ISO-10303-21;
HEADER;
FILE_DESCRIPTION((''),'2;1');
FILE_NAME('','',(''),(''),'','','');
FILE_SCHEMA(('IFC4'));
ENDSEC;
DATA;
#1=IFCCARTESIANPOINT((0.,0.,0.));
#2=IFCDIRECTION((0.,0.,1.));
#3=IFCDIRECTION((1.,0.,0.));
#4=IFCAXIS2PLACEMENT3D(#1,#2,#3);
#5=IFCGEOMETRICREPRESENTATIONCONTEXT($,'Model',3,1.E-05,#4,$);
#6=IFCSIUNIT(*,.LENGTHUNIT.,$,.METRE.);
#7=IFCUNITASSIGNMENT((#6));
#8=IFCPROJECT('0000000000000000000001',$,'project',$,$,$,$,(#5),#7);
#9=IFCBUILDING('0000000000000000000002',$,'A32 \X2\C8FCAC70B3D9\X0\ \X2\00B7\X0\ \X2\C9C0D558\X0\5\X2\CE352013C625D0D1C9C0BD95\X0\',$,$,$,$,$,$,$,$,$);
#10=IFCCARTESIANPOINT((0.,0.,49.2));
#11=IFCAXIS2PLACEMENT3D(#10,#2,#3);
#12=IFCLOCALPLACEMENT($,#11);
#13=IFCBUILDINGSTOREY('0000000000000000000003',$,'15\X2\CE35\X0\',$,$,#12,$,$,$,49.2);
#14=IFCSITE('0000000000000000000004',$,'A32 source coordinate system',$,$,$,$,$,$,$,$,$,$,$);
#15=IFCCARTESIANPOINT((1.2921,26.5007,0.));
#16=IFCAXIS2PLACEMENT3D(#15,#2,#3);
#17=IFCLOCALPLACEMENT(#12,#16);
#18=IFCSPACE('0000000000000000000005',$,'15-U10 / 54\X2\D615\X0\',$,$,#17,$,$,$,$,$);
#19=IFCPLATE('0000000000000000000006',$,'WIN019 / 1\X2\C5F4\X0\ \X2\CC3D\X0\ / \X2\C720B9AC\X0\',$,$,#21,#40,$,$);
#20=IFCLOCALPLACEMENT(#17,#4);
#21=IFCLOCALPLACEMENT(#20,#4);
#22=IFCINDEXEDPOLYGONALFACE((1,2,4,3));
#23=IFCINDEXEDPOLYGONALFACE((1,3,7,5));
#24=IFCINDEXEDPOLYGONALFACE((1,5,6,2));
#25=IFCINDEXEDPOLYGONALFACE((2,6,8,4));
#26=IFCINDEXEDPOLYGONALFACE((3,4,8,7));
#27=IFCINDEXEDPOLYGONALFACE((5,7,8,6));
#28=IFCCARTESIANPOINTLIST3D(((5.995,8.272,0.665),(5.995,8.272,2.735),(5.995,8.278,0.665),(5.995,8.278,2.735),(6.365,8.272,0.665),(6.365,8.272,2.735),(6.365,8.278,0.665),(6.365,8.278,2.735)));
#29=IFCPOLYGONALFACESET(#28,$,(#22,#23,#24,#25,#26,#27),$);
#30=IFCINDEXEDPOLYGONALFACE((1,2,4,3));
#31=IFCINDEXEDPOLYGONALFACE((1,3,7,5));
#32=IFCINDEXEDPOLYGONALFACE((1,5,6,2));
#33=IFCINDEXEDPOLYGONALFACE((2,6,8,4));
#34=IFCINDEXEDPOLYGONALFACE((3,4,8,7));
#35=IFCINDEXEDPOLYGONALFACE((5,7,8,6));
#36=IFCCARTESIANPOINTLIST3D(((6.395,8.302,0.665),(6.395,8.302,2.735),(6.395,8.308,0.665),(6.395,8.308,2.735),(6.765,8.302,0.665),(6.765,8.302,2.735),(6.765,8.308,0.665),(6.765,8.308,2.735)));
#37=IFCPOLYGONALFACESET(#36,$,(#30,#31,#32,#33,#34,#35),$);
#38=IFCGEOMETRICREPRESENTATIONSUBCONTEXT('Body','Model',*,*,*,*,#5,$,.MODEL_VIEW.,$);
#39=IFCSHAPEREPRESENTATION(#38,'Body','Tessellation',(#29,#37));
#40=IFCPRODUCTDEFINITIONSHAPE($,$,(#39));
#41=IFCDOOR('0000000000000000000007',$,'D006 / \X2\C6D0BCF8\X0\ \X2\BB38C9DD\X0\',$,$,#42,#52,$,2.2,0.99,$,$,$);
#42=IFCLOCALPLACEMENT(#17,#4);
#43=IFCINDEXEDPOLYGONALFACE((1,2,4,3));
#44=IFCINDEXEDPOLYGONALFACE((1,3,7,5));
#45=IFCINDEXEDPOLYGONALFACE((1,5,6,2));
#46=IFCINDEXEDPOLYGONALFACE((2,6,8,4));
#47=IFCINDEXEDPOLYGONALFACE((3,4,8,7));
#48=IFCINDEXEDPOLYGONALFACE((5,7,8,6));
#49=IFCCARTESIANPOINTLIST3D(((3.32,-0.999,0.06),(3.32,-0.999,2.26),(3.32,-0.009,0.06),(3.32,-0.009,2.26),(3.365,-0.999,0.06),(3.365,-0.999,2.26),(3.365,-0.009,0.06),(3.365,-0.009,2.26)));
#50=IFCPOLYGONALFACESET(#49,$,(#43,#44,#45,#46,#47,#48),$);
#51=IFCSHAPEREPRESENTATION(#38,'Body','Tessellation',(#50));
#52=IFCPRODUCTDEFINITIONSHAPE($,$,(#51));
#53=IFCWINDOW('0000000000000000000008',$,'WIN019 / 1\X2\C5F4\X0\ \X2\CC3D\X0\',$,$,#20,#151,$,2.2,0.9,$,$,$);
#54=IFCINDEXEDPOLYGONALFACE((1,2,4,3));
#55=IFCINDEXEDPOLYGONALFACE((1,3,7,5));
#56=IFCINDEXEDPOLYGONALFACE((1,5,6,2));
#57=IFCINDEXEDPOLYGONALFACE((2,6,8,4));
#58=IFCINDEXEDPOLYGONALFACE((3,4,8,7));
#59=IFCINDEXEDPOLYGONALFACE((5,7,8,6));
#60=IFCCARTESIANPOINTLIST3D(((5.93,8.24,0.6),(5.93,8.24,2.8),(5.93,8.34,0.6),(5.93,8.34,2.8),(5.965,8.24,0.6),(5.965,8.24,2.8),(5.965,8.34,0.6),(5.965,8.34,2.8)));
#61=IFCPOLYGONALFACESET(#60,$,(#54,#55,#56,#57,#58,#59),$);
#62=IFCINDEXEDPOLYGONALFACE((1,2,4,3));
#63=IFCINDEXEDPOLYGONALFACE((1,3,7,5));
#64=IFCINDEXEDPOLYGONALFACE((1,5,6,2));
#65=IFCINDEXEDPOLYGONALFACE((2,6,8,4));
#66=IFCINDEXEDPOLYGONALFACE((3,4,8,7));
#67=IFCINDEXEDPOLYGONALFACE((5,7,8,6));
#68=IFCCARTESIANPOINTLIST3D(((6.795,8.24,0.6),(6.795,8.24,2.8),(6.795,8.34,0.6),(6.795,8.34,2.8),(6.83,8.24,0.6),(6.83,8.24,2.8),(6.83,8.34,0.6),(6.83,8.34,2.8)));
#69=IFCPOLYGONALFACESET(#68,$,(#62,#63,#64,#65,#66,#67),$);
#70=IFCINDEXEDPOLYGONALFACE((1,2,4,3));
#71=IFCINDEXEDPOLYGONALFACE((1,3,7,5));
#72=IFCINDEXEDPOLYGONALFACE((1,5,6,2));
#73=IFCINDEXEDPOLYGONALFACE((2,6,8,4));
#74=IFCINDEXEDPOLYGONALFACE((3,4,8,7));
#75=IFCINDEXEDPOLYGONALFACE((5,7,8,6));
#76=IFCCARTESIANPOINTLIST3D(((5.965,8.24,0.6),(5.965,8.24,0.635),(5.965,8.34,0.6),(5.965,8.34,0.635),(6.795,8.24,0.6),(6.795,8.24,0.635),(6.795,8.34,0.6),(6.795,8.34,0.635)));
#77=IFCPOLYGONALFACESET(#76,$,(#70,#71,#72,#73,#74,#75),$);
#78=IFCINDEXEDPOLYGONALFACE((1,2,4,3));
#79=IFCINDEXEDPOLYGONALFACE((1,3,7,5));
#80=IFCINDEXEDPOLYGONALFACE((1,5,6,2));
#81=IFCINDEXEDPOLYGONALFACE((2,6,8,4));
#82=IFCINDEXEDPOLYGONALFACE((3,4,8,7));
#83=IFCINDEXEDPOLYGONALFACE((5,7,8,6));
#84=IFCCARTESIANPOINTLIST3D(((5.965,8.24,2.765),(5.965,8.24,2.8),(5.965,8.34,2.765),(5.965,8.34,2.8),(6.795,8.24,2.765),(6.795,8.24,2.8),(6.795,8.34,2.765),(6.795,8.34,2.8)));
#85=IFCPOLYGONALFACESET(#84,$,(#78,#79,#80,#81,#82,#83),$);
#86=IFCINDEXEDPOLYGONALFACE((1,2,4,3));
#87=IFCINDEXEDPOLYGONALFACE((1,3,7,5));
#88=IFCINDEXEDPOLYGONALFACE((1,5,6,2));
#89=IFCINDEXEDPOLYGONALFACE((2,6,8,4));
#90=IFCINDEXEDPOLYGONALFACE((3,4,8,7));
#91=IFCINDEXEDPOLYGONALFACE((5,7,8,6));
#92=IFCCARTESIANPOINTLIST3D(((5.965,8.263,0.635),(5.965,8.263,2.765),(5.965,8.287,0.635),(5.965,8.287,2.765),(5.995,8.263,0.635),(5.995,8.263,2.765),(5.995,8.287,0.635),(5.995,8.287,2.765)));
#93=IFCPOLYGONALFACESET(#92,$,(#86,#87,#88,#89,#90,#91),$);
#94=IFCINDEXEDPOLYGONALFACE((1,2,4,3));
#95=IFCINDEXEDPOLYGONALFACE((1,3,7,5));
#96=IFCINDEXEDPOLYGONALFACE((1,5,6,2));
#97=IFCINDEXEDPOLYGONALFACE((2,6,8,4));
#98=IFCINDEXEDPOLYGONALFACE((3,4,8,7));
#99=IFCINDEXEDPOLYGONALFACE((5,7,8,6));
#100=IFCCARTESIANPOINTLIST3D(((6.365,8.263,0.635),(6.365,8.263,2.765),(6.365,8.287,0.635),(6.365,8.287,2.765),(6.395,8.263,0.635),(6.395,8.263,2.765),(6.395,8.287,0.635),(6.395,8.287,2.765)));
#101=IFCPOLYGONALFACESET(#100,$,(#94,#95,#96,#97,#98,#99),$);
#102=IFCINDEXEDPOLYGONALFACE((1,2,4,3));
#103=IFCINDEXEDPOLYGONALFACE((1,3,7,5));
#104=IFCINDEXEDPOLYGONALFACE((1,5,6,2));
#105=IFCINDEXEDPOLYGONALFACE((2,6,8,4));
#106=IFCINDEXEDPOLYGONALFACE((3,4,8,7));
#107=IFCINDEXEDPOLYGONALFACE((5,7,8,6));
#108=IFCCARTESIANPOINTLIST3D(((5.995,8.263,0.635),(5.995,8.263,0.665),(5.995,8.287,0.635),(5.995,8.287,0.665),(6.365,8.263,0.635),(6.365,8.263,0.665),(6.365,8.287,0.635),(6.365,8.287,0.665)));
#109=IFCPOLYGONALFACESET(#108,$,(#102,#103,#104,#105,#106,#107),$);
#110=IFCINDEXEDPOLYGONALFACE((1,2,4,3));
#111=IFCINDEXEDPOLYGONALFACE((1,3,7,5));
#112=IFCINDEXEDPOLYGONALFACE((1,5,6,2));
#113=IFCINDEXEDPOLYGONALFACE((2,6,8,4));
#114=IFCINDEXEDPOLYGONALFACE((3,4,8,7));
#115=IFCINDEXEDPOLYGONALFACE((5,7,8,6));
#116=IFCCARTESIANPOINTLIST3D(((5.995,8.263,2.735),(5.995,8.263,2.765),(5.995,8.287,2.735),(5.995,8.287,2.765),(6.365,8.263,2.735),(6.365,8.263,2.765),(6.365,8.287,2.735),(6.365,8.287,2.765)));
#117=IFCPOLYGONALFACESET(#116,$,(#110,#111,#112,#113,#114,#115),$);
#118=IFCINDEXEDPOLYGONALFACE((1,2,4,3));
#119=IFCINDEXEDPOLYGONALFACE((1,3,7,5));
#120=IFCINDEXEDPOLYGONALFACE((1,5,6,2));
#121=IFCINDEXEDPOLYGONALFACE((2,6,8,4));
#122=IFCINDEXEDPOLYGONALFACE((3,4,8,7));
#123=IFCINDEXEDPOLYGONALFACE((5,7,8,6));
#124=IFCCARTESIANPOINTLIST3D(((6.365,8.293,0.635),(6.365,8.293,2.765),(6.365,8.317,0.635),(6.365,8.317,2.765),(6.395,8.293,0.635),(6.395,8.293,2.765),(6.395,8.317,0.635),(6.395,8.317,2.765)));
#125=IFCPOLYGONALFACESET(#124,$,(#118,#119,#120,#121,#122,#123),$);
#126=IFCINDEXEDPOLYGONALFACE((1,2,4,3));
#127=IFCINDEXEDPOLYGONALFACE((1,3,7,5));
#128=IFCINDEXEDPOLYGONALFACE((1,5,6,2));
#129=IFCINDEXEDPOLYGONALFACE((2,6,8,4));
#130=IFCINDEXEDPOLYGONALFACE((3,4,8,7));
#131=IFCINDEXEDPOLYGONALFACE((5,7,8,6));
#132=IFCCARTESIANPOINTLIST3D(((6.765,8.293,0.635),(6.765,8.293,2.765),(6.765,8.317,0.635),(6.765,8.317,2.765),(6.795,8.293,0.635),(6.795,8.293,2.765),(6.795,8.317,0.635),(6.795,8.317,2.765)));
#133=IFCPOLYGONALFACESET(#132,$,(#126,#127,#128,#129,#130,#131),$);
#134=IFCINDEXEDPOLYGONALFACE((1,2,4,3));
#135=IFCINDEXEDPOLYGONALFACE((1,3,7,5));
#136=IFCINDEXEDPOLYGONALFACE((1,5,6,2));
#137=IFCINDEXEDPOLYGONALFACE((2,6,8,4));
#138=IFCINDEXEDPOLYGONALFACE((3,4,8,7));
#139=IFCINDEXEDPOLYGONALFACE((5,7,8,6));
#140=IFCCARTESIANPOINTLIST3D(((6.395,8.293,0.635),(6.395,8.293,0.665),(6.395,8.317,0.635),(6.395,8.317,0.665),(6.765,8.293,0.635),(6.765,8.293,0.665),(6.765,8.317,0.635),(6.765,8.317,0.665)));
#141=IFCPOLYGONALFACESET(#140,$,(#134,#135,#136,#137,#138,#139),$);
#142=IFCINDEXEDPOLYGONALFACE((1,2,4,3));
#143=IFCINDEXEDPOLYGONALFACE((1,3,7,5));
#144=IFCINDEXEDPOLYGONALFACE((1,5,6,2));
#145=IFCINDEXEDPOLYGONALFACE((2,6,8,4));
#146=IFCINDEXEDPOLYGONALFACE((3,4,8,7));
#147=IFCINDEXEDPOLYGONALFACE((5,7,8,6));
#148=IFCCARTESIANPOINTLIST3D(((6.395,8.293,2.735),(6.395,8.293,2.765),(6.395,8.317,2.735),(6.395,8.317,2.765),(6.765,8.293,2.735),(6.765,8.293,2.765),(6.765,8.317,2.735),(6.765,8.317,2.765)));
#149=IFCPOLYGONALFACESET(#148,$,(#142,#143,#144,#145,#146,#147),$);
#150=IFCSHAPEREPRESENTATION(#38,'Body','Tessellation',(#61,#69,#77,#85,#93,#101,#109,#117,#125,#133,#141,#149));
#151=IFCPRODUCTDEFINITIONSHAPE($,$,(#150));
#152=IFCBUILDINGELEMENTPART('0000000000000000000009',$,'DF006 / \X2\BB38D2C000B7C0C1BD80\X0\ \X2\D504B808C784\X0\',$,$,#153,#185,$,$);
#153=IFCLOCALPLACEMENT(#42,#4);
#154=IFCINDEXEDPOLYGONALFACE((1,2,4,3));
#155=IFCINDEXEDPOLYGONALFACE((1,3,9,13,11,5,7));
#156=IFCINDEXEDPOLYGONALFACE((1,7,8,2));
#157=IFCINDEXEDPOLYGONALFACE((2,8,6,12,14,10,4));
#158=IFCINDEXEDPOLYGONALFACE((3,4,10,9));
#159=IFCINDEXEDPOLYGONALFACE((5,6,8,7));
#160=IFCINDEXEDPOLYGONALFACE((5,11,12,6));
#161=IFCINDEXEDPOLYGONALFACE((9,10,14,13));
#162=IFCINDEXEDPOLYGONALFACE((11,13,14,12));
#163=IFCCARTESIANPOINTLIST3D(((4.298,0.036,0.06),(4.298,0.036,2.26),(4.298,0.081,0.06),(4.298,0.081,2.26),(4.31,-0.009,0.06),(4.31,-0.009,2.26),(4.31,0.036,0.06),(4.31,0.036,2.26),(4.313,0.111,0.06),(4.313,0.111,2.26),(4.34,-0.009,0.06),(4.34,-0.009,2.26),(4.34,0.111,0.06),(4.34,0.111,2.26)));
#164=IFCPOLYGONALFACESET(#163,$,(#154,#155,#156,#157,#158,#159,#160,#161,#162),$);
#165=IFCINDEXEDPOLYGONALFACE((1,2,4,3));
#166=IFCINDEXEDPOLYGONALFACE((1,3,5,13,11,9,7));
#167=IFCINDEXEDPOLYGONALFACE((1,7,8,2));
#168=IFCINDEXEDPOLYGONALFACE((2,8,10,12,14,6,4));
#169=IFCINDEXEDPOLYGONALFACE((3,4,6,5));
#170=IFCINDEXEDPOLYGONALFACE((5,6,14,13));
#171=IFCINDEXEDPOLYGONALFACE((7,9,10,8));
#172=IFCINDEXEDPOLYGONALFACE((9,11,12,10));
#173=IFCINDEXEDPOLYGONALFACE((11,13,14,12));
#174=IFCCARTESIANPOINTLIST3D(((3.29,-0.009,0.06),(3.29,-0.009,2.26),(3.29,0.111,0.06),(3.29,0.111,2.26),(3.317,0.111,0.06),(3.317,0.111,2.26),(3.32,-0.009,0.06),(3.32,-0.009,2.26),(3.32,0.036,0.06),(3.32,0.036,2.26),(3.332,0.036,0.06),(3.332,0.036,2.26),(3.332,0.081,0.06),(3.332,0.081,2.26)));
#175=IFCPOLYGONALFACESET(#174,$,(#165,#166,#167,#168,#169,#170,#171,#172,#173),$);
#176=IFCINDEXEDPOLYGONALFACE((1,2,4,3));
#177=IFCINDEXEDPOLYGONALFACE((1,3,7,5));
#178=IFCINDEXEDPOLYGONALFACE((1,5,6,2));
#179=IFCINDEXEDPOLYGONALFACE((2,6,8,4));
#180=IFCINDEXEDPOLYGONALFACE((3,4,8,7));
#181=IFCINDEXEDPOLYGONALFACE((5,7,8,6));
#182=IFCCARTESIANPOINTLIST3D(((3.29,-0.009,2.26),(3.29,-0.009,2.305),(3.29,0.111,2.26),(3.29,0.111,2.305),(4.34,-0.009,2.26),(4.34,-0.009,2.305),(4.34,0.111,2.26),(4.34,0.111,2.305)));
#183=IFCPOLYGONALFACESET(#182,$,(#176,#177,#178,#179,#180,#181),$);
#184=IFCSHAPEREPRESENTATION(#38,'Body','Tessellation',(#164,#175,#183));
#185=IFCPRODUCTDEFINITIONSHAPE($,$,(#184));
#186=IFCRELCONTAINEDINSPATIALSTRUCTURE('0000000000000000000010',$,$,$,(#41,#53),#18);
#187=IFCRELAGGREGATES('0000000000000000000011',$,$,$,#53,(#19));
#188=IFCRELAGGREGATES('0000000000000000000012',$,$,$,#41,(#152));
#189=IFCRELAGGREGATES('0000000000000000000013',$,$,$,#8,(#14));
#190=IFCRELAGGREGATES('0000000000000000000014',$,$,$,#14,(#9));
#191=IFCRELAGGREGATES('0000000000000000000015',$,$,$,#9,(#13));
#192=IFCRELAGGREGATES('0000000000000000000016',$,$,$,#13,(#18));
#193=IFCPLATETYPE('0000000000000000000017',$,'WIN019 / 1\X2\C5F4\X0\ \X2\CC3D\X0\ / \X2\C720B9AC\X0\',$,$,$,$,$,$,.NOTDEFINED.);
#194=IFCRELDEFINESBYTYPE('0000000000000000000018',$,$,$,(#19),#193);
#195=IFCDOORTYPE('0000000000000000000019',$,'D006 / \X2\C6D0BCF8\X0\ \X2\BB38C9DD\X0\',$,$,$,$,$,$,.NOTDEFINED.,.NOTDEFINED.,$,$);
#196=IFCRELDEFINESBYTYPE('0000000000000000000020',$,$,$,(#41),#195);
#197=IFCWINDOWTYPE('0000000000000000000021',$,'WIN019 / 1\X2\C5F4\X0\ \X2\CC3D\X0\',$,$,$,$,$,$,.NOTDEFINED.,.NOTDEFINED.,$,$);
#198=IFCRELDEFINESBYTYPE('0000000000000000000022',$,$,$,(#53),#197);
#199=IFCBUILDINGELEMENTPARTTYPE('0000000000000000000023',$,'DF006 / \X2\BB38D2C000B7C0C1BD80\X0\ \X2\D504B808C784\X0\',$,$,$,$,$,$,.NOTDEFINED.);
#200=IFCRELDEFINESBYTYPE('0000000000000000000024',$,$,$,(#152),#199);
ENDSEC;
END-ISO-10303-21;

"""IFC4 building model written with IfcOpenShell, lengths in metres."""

from ifc_helpers import new_model, si_unit, frame, origin, origin_with_axes, place, context, subcontext, project, spatial, polyline, outline, extrude, source, transform, mapped, type_object, type_shapes, element, aggregate, save


model = new_model("IFC4")

# Units and contexts
model_context = context("Model", 3, precision=1e-05, world=origin_with_axes())
body_context = subcontext(model_context, "Body", "Model", "MODEL_VIEW")
ifc_project = project(units=[si_unit("LENGTHUNIT", "METRE")], contexts=[model_context])

# Plate
storey_placement = place(None, frame((0.0, 0.0, 49.2), z_axis=(0.0, 0.0, 1.0), x_axis=(1.0, 0.0, 0.0)))
space_placement = place(storey_placement, frame((1.2921, 26.5007, 0.0), z_axis=(0.0, 0.0, 1.0), x_axis=(1.0, 0.0, 0.0)))
plate_type_1 = type_object("IfcPlateType", Name="WIN019 / 1열 창 / 유리", PredefinedType="NOTDEFINED")
shared_shape_1 = source(origin(), body_context, "Body", "SweptSolid", [
    extrude(outline(polyline([(5.995, 8.272), (5.995, 8.278), (6.365, 8.278), (6.365, 8.272), (5.995, 8.272)])), frame((0.0, 0.0, 0.665)), (0.0, 0.0, 1.0), 2.07),
    extrude(outline(polyline([(6.395, 8.302), (6.395, 8.308), (6.765, 8.308), (6.765, 8.302), (6.395, 8.302)])), frame((0.0, 0.0, 0.665)), (0.0, 0.0, 1.0), 2.07),
])
type_shapes(plate_type_1, [shared_shape_1])
window_1_placement = place(space_placement, origin_with_axes())
plate_1_placement = place(window_1_placement, origin_with_axes())
plate_1 = element("IfcPlate", 1, at=plate_1_placement, type_object=plate_type_1, Name="WIN019 / 1열 창 / 유리", context=body_context, shape_type="MappedRepresentation", body=[
    mapped(shared_shape_1, transform((0.0, 0.0, 0.0), scale=1.0)),
])

# Site, building, storey, space
site = spatial("IfcSite", under=ifc_project, Name="A32 source coordinate system")
building = spatial("IfcBuilding", under=site, Name="A32 주거동 · 지하5층–옥탑지붕")
storey = spatial("IfcBuildingStorey", under=building, at=storey_placement, Name="15층", Elevation=49.2)
space = spatial("IfcSpace", under=storey, at=space_placement, Name="15-U10 / 54형")

# Door
door_type_1 = type_object("IfcDoorType", Name="D006 / 원본 문짝", OperationType="NOTDEFINED", PredefinedType="NOTDEFINED")
shared_shape_2 = source(origin(), body_context, "Body", "SweptSolid", [
    extrude(outline(polyline([(3.365, -0.999), (3.32, -0.999), (3.32, -0.009), (3.365, -0.009), (3.365, -0.999)])), frame((0.0, 0.0, 0.06)), (0.0, 0.0, 1.0), 2.2),
])
type_shapes(door_type_1, [shared_shape_2])
door_1_placement = place(space_placement, origin_with_axes())
door_1 = element("IfcDoor", 2, at=door_1_placement, inside=space, type_object=door_type_1, Name="D006 / 원본 문짝", OverallHeight=2.2, OverallWidth=0.99, context=body_context, shape_type="MappedRepresentation", body=[
    mapped(shared_shape_2, transform((0.0, 0.0, 0.0), scale=1.0)),
])

# Window
window_type_1 = type_object("IfcWindowType", Name="WIN019 / 1열 창", PartitioningType="NOTDEFINED", PredefinedType="NOTDEFINED")
shared_shape_3 = source(origin(), body_context, "Body", "SweptSolid", [
    extrude(outline(polyline([(5.93, 8.24), (5.93, 8.34), (5.965, 8.34), (5.965, 8.24), (5.93, 8.24)])), frame((0.0, 0.0, 0.6)), (0.0, 0.0, 1.0), 2.2),
    extrude(outline(polyline([(6.795, 8.24), (6.795, 8.34), (6.83, 8.34), (6.83, 8.24), (6.795, 8.24)])), frame((0.0, 0.0, 0.6)), (0.0, 0.0, 1.0), 2.2),
    extrude(outline(polyline([(5.965, 8.24), (5.965, 8.34), (6.795, 8.34), (6.795, 8.24), (5.965, 8.24)])), frame((0.0, 0.0, 0.6)), (0.0, 0.0, 1.0), 0.035),
    extrude(outline(polyline([(5.965, 8.24), (5.965, 8.34), (6.795, 8.34), (6.795, 8.24), (5.965, 8.24)])), frame((0.0, 0.0, 2.765)), (0.0, 0.0, 1.0), 0.035),
    extrude(outline(polyline([(5.965, 8.263), (5.965, 8.287), (5.995, 8.287), (5.995, 8.263), (5.965, 8.263)])), frame((0.0, 0.0, 0.635)), (0.0, 0.0, 1.0), 2.13),
    extrude(outline(polyline([(6.365, 8.263), (6.365, 8.287), (6.395, 8.287), (6.395, 8.263), (6.365, 8.263)])), frame((0.0, 0.0, 0.635)), (0.0, 0.0, 1.0), 2.13),
    extrude(outline(polyline([(5.995, 8.263), (5.995, 8.287), (6.365, 8.287), (6.365, 8.263), (5.995, 8.263)])), frame((0.0, 0.0, 0.635)), (0.0, 0.0, 1.0), 0.03),
    extrude(outline(polyline([(5.995, 8.263), (5.995, 8.287), (6.365, 8.287), (6.365, 8.263), (5.995, 8.263)])), frame((0.0, 0.0, 2.735)), (0.0, 0.0, 1.0), 0.03),
    extrude(outline(polyline([(6.365, 8.293), (6.365, 8.317), (6.395, 8.317), (6.395, 8.293), (6.365, 8.293)])), frame((0.0, 0.0, 0.635)), (0.0, 0.0, 1.0), 2.13),
    extrude(outline(polyline([(6.765, 8.293), (6.765, 8.317), (6.795, 8.317), (6.795, 8.293), (6.765, 8.293)])), frame((0.0, 0.0, 0.635)), (0.0, 0.0, 1.0), 2.13),
    extrude(outline(polyline([(6.395, 8.293), (6.395, 8.317), (6.765, 8.317), (6.765, 8.293), (6.395, 8.293)])), frame((0.0, 0.0, 0.635)), (0.0, 0.0, 1.0), 0.03),
    extrude(outline(polyline([(6.395, 8.293), (6.395, 8.317), (6.765, 8.317), (6.765, 8.293), (6.395, 8.293)])), frame((0.0, 0.0, 2.735)), (0.0, 0.0, 1.0), 0.03),
])
type_shapes(window_type_1, [shared_shape_3])
window_1 = element("IfcWindow", 3, at=window_1_placement, inside=space, type_object=window_type_1, Name="WIN019 / 1열 창", OverallHeight=2.2, OverallWidth=0.9, context=body_context, shape_type="MappedRepresentation", body=[
    mapped(shared_shape_3, transform((0.0, 0.0, 0.0), scale=1.0)),
])
aggregate(window_1, [plate_1])

# Building element part
building_element_part_type_1 = type_object("IfcBuildingElementPartType", Name="DF006 / 문틀·상부 프레임", PredefinedType="NOTDEFINED")
shared_shape_4 = source(origin(), body_context, "Body", "SweptSolid", [
    extrude(outline(polyline([(4.31, -0.009), (4.31, 0.036), (4.298, 0.036), (4.298, 0.081), (4.313, 0.111), (4.34, 0.111), (4.34, -0.009), (4.31, -0.009)])), frame((0.0, 0.0, 0.06)), (0.0, 0.0, 1.0), 2.2),
    extrude(outline(polyline([(3.29, 0.111), (3.317, 0.111), (3.332, 0.081), (3.332, 0.036), (3.32, 0.036), (3.32, -0.009), (3.29, -0.009), (3.29, 0.111)])), frame((0.0, 0.0, 0.06)), (0.0, 0.0, 1.0), 2.2),
    extrude(outline(polyline([(3.29, -0.009), (3.29, 0.111), (4.34, 0.111), (4.34, -0.009), (3.29, -0.009)])), frame((0.0, 0.0, 2.26)), (0.0, 0.0, 1.0), 0.045),
])
type_shapes(building_element_part_type_1, [shared_shape_4])
building_element_part_1_placement = place(door_1_placement, origin_with_axes())
building_element_part_1 = element("IfcBuildingElementPart", 4, at=building_element_part_1_placement, type_object=building_element_part_type_1, Name="DF006 / 문틀·상부 프레임", context=body_context, shape_type="MappedRepresentation", body=[
    mapped(shared_shape_4, transform((0.0, 0.0, 0.0), scale=1.0)),
])
aggregate(door_1, [building_element_part_1])

save(model, "model.ifc")
